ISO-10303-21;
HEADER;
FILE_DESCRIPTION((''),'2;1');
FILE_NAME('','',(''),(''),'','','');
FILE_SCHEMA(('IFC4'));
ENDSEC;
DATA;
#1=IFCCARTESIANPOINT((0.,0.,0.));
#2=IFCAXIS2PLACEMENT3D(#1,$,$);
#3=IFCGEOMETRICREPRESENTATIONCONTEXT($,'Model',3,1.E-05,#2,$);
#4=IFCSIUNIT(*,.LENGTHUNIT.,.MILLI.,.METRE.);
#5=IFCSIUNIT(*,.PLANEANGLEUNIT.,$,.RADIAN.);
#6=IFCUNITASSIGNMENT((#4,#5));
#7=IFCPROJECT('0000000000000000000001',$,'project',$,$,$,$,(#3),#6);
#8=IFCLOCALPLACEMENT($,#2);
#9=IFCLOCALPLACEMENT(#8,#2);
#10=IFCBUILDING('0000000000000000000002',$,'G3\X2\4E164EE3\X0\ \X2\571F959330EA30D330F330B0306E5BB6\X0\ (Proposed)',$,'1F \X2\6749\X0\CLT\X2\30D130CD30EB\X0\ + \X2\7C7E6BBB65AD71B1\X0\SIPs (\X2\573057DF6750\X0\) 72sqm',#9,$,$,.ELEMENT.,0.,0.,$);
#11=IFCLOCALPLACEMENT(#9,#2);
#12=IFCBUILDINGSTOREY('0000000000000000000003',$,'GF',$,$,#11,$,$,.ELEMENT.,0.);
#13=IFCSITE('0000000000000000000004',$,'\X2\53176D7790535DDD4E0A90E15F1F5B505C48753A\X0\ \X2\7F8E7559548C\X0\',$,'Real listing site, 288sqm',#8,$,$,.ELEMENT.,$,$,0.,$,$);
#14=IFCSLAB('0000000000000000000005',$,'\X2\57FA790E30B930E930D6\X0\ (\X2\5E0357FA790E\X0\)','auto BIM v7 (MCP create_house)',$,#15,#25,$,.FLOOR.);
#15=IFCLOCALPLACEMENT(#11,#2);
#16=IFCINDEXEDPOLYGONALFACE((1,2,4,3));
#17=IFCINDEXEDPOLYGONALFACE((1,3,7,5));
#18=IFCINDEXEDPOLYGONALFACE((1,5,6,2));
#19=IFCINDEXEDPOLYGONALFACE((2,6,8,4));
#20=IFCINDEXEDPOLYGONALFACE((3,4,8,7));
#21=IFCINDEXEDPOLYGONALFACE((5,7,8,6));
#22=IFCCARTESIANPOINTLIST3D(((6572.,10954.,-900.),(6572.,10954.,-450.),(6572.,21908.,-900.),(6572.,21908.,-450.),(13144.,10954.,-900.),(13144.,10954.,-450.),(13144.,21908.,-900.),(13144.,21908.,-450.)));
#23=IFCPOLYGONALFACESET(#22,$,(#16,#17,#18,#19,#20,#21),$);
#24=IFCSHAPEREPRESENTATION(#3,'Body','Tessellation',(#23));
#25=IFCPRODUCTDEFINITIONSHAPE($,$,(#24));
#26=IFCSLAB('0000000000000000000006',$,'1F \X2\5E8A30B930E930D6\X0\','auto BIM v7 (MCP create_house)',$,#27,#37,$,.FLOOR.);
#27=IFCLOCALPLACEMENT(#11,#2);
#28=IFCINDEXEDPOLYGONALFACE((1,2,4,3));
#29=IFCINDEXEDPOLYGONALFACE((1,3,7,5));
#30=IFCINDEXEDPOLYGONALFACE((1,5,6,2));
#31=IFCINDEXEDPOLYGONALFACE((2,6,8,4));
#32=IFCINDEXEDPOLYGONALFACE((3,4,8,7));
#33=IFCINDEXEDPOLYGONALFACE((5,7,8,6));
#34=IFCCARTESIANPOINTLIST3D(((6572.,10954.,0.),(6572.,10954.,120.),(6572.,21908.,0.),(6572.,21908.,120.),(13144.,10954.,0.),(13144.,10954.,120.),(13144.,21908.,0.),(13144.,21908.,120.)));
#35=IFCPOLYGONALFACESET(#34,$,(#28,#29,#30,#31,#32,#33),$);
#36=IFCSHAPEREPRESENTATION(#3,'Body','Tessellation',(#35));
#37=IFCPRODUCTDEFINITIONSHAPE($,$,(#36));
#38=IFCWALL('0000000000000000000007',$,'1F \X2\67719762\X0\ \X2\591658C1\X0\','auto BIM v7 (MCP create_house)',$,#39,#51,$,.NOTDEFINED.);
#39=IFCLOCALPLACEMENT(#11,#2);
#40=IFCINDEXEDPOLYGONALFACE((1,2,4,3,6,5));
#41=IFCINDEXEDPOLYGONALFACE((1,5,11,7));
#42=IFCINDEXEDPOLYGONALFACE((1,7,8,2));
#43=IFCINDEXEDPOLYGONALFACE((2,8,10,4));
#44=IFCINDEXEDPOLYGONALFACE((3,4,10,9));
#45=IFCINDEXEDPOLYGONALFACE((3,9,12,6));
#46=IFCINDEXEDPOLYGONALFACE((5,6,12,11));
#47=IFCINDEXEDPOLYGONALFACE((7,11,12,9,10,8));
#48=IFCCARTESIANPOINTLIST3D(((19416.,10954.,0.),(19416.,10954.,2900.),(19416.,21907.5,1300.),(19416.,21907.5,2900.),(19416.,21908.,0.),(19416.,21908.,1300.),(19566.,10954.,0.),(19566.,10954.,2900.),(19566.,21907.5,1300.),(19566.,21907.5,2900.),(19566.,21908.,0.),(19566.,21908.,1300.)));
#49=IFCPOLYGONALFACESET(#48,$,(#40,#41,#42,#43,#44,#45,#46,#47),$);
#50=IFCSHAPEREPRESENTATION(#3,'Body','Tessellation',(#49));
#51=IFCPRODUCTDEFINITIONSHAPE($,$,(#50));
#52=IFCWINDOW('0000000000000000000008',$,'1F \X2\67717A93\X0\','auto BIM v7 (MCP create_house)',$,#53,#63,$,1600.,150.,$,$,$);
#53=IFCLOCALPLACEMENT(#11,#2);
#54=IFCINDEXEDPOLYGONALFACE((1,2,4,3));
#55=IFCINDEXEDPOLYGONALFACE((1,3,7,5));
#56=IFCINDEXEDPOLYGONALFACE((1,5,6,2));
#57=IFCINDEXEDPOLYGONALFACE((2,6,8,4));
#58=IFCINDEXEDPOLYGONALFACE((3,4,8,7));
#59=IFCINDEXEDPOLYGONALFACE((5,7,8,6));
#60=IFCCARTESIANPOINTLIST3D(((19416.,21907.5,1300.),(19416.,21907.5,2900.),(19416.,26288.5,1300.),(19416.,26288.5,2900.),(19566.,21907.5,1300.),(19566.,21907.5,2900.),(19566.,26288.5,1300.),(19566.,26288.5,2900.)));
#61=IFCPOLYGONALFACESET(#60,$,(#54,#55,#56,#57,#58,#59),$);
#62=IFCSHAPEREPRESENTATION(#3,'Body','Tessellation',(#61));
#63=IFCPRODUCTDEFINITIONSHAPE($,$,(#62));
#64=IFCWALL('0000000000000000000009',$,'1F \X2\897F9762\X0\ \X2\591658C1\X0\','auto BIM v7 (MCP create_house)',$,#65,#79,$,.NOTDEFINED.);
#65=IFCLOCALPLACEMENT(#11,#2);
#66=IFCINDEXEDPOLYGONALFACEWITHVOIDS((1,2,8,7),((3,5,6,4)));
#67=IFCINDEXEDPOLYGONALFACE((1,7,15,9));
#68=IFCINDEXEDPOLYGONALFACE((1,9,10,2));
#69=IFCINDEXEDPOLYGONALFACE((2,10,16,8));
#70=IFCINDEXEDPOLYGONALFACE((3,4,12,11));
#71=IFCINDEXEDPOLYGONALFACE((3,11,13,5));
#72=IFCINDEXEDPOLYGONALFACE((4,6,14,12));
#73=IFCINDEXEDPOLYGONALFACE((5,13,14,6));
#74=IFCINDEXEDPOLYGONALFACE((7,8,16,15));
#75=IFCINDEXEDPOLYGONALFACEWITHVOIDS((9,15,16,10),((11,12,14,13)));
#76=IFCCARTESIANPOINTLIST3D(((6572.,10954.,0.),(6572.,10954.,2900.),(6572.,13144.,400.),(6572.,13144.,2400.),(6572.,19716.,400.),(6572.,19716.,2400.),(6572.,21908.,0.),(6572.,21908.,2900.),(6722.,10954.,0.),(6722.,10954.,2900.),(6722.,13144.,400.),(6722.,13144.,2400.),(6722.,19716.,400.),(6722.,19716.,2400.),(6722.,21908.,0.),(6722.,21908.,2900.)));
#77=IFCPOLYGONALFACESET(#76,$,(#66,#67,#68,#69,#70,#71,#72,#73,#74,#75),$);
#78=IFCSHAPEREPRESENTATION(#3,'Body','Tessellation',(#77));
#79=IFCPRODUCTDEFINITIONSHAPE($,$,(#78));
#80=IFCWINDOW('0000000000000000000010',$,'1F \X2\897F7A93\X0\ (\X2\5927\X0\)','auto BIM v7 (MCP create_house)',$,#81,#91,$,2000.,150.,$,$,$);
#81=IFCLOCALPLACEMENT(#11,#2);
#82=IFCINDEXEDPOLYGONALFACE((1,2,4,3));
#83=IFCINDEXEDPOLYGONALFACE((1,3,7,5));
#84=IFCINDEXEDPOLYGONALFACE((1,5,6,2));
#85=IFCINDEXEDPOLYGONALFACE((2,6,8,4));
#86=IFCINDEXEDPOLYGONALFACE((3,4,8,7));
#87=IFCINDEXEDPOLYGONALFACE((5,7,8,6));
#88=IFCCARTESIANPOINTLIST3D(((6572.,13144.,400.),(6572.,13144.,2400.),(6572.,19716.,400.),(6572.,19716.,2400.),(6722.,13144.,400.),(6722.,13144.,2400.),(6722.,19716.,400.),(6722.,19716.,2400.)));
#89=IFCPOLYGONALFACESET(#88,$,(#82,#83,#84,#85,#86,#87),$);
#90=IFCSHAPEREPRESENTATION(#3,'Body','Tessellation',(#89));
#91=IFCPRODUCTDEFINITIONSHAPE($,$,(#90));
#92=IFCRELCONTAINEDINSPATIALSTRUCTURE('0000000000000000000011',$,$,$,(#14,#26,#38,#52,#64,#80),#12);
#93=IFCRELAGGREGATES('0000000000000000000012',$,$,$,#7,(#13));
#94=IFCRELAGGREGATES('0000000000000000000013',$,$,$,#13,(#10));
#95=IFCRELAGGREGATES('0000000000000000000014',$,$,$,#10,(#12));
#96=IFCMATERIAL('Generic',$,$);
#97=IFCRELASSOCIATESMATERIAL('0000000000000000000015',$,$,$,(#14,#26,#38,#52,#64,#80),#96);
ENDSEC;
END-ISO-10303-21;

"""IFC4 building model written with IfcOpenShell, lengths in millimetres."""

from ifc_helpers import new_model, si_unit, frame, frame_2d, origin, place, context, project, spatial, rectangle, extrude, material, element, fill, save


model = new_model("IFC4")

# Units and contexts
model_context = context("Model", 3, precision=1e-05, world=origin())
ifc_project = project(units=[si_unit("LENGTHUNIT", "METRE", prefix="MILLI"), si_unit("PLANEANGLEUNIT", "RADIAN")], contexts=[model_context])

# Site, building, storey
site_placement = place(None, origin())
site = spatial("IfcSite", under=ifc_project, at=site_placement, Name="北海道川上郡弟子屈町 美留和", ObjectType="Real listing site, 288sqm", CompositionType="ELEMENT", RefElevation=0.0)
building_placement = place(site_placement, origin())
building = spatial("IfcBuilding", under=site, at=building_placement, Name="G3世代 土間リビングの家 (Proposed)", ObjectType="1F 杉CLTパネル + 籾殻断熱SIPs (地域材) 72sqm", CompositionType="ELEMENT", ElevationOfRefHeight=0.0, ElevationOfTerrain=0.0)
storey_placement = place(building_placement, origin())
storey = spatial("IfcBuildingStorey", under=building, at=storey_placement, Name="GF", CompositionType="ELEMENT", Elevation=0.0)

# Slabs
ifc_material = material(Name="Generic")
slab_1_placement = place(storey_placement, frame((3286.0, 5477.0, -450.0)))
element("IfcSlab", 1, at=slab_1_placement, inside=storey, material=ifc_material, Name="基礎スラブ (布基礎)", Description="auto BIM v7 (MCP create_house)", PredefinedType="FLOOR", context=model_context, shape_type="SweptSolid", body=[
    extrude(rectangle(XDim=6572.0, YDim=10954.0, at=frame_2d((3286.0, 5477.0))), frame((3286.0, 5477.0, -450.0)), (0.0, 0.0, 1.0), 450.0),
])
slab_2_placement = place(storey_placement, frame((3286.0, 5477.0, 0.0)))
element("IfcSlab", 2, at=slab_2_placement, inside=storey, material=ifc_material, Name="1F 床スラブ", Description="auto BIM v7 (MCP create_house)", PredefinedType="FLOOR", context=model_context, shape_type="SweptSolid", body=[
    extrude(rectangle(XDim=6572.0, YDim=10954.0, at=frame_2d((3286.0, 5477.0))), frame((3286.0, 5477.0, 0.0)), (0.0, 0.0, 1.0), 120.0),
])

# Walls, openings, windows
wall_1_placement = place(storey_placement, frame((9708.0, 5477.0, 0.0)))
wall_1 = element("IfcWall", 3, at=wall_1_placement, inside=storey, material=ifc_material, Name="1F 東面 外壁", Description="auto BIM v7 (MCP create_house)", PredefinedType="NOTDEFINED", context=model_context, shape_type="SweptSolid", body=[
    extrude(rectangle(XDim=150.0, YDim=10954.0, at=frame_2d((75.0, 5477.0))), frame((9708.0, 5477.0, 0.0)), (0.0, 0.0, 1.0), 2900.0),
])
opening_1_placement = place(storey_placement, frame((9708.0, 10954.0, 650.0)))
opening_1 = element("IfcOpeningElement", 4, at=opening_1_placement, cuts=wall_1, PredefinedType="NOTDEFINED", context=model_context, shape_type="SweptSolid", body=[
    extrude(rectangle(XDim=150.0, YDim=4381.0, at=frame_2d((75.0, 2190.0))), frame((9708.0, 10954.0, 650.0)), (0.0, 0.0, 1.0), 1600.0),
])
window_1_placement = place(storey_placement, frame((9708.0, 10954.0, 650.0)))
window_1 = element("IfcWindow", 5, at=window_1_placement, inside=storey, material=ifc_material, Name="1F 東窓", Description="auto BIM v7 (MCP create_house)", OverallHeight=1600.0, OverallWidth=150.0, context=model_context, shape_type="SweptSolid", body=[
    extrude(rectangle(XDim=150.0, YDim=4381.0, at=frame_2d((75.0, 2190.0))), frame((9708.0, 10954.0, 650.0)), (0.0, 0.0, 1.0), 1600.0),
])
fill(opening_1, window_1)
wall_2_placement = place(storey_placement, frame((3286.0, 5477.0, 0.0)))
wall_2 = element("IfcWall", 6, at=wall_2_placement, inside=storey, material=ifc_material, Name="1F 西面 外壁", Description="auto BIM v7 (MCP create_house)", PredefinedType="NOTDEFINED", context=model_context, shape_type="SweptSolid", body=[
    extrude(rectangle(XDim=150.0, YDim=10954.0, at=frame_2d((75.0, 5477.0))), frame((3286.0, 5477.0, 0.0)), (0.0, 0.0, 1.0), 2900.0),
])
opening_2_placement = place(storey_placement, frame((3286.0, 6572.0, 200.0)))
opening_2 = element("IfcOpeningElement", 7, at=opening_2_placement, cuts=wall_2, PredefinedType="NOTDEFINED", context=model_context, shape_type="SweptSolid", body=[
    extrude(rectangle(XDim=150.0, YDim=6572.0, at=frame_2d((75.0, 3286.0))), frame((3286.0, 6572.0, 200.0)), (0.0, 0.0, 1.0), 2000.0),
])
window_2_placement = place(storey_placement, frame((3286.0, 6572.0, 200.0)))
window_2 = element("IfcWindow", 8, at=window_2_placement, inside=storey, material=ifc_material, Name="1F 西窓 (大)", Description="auto BIM v7 (MCP create_house)", OverallHeight=2000.0, OverallWidth=150.0, context=model_context, shape_type="SweptSolid", body=[
    extrude(rectangle(XDim=150.0, YDim=6572.0, at=frame_2d((75.0, 3286.0))), frame((3286.0, 6572.0, 200.0)), (0.0, 0.0, 1.0), 2000.0),
])
fill(opening_2, window_2)

save(model, "model.ifc")
